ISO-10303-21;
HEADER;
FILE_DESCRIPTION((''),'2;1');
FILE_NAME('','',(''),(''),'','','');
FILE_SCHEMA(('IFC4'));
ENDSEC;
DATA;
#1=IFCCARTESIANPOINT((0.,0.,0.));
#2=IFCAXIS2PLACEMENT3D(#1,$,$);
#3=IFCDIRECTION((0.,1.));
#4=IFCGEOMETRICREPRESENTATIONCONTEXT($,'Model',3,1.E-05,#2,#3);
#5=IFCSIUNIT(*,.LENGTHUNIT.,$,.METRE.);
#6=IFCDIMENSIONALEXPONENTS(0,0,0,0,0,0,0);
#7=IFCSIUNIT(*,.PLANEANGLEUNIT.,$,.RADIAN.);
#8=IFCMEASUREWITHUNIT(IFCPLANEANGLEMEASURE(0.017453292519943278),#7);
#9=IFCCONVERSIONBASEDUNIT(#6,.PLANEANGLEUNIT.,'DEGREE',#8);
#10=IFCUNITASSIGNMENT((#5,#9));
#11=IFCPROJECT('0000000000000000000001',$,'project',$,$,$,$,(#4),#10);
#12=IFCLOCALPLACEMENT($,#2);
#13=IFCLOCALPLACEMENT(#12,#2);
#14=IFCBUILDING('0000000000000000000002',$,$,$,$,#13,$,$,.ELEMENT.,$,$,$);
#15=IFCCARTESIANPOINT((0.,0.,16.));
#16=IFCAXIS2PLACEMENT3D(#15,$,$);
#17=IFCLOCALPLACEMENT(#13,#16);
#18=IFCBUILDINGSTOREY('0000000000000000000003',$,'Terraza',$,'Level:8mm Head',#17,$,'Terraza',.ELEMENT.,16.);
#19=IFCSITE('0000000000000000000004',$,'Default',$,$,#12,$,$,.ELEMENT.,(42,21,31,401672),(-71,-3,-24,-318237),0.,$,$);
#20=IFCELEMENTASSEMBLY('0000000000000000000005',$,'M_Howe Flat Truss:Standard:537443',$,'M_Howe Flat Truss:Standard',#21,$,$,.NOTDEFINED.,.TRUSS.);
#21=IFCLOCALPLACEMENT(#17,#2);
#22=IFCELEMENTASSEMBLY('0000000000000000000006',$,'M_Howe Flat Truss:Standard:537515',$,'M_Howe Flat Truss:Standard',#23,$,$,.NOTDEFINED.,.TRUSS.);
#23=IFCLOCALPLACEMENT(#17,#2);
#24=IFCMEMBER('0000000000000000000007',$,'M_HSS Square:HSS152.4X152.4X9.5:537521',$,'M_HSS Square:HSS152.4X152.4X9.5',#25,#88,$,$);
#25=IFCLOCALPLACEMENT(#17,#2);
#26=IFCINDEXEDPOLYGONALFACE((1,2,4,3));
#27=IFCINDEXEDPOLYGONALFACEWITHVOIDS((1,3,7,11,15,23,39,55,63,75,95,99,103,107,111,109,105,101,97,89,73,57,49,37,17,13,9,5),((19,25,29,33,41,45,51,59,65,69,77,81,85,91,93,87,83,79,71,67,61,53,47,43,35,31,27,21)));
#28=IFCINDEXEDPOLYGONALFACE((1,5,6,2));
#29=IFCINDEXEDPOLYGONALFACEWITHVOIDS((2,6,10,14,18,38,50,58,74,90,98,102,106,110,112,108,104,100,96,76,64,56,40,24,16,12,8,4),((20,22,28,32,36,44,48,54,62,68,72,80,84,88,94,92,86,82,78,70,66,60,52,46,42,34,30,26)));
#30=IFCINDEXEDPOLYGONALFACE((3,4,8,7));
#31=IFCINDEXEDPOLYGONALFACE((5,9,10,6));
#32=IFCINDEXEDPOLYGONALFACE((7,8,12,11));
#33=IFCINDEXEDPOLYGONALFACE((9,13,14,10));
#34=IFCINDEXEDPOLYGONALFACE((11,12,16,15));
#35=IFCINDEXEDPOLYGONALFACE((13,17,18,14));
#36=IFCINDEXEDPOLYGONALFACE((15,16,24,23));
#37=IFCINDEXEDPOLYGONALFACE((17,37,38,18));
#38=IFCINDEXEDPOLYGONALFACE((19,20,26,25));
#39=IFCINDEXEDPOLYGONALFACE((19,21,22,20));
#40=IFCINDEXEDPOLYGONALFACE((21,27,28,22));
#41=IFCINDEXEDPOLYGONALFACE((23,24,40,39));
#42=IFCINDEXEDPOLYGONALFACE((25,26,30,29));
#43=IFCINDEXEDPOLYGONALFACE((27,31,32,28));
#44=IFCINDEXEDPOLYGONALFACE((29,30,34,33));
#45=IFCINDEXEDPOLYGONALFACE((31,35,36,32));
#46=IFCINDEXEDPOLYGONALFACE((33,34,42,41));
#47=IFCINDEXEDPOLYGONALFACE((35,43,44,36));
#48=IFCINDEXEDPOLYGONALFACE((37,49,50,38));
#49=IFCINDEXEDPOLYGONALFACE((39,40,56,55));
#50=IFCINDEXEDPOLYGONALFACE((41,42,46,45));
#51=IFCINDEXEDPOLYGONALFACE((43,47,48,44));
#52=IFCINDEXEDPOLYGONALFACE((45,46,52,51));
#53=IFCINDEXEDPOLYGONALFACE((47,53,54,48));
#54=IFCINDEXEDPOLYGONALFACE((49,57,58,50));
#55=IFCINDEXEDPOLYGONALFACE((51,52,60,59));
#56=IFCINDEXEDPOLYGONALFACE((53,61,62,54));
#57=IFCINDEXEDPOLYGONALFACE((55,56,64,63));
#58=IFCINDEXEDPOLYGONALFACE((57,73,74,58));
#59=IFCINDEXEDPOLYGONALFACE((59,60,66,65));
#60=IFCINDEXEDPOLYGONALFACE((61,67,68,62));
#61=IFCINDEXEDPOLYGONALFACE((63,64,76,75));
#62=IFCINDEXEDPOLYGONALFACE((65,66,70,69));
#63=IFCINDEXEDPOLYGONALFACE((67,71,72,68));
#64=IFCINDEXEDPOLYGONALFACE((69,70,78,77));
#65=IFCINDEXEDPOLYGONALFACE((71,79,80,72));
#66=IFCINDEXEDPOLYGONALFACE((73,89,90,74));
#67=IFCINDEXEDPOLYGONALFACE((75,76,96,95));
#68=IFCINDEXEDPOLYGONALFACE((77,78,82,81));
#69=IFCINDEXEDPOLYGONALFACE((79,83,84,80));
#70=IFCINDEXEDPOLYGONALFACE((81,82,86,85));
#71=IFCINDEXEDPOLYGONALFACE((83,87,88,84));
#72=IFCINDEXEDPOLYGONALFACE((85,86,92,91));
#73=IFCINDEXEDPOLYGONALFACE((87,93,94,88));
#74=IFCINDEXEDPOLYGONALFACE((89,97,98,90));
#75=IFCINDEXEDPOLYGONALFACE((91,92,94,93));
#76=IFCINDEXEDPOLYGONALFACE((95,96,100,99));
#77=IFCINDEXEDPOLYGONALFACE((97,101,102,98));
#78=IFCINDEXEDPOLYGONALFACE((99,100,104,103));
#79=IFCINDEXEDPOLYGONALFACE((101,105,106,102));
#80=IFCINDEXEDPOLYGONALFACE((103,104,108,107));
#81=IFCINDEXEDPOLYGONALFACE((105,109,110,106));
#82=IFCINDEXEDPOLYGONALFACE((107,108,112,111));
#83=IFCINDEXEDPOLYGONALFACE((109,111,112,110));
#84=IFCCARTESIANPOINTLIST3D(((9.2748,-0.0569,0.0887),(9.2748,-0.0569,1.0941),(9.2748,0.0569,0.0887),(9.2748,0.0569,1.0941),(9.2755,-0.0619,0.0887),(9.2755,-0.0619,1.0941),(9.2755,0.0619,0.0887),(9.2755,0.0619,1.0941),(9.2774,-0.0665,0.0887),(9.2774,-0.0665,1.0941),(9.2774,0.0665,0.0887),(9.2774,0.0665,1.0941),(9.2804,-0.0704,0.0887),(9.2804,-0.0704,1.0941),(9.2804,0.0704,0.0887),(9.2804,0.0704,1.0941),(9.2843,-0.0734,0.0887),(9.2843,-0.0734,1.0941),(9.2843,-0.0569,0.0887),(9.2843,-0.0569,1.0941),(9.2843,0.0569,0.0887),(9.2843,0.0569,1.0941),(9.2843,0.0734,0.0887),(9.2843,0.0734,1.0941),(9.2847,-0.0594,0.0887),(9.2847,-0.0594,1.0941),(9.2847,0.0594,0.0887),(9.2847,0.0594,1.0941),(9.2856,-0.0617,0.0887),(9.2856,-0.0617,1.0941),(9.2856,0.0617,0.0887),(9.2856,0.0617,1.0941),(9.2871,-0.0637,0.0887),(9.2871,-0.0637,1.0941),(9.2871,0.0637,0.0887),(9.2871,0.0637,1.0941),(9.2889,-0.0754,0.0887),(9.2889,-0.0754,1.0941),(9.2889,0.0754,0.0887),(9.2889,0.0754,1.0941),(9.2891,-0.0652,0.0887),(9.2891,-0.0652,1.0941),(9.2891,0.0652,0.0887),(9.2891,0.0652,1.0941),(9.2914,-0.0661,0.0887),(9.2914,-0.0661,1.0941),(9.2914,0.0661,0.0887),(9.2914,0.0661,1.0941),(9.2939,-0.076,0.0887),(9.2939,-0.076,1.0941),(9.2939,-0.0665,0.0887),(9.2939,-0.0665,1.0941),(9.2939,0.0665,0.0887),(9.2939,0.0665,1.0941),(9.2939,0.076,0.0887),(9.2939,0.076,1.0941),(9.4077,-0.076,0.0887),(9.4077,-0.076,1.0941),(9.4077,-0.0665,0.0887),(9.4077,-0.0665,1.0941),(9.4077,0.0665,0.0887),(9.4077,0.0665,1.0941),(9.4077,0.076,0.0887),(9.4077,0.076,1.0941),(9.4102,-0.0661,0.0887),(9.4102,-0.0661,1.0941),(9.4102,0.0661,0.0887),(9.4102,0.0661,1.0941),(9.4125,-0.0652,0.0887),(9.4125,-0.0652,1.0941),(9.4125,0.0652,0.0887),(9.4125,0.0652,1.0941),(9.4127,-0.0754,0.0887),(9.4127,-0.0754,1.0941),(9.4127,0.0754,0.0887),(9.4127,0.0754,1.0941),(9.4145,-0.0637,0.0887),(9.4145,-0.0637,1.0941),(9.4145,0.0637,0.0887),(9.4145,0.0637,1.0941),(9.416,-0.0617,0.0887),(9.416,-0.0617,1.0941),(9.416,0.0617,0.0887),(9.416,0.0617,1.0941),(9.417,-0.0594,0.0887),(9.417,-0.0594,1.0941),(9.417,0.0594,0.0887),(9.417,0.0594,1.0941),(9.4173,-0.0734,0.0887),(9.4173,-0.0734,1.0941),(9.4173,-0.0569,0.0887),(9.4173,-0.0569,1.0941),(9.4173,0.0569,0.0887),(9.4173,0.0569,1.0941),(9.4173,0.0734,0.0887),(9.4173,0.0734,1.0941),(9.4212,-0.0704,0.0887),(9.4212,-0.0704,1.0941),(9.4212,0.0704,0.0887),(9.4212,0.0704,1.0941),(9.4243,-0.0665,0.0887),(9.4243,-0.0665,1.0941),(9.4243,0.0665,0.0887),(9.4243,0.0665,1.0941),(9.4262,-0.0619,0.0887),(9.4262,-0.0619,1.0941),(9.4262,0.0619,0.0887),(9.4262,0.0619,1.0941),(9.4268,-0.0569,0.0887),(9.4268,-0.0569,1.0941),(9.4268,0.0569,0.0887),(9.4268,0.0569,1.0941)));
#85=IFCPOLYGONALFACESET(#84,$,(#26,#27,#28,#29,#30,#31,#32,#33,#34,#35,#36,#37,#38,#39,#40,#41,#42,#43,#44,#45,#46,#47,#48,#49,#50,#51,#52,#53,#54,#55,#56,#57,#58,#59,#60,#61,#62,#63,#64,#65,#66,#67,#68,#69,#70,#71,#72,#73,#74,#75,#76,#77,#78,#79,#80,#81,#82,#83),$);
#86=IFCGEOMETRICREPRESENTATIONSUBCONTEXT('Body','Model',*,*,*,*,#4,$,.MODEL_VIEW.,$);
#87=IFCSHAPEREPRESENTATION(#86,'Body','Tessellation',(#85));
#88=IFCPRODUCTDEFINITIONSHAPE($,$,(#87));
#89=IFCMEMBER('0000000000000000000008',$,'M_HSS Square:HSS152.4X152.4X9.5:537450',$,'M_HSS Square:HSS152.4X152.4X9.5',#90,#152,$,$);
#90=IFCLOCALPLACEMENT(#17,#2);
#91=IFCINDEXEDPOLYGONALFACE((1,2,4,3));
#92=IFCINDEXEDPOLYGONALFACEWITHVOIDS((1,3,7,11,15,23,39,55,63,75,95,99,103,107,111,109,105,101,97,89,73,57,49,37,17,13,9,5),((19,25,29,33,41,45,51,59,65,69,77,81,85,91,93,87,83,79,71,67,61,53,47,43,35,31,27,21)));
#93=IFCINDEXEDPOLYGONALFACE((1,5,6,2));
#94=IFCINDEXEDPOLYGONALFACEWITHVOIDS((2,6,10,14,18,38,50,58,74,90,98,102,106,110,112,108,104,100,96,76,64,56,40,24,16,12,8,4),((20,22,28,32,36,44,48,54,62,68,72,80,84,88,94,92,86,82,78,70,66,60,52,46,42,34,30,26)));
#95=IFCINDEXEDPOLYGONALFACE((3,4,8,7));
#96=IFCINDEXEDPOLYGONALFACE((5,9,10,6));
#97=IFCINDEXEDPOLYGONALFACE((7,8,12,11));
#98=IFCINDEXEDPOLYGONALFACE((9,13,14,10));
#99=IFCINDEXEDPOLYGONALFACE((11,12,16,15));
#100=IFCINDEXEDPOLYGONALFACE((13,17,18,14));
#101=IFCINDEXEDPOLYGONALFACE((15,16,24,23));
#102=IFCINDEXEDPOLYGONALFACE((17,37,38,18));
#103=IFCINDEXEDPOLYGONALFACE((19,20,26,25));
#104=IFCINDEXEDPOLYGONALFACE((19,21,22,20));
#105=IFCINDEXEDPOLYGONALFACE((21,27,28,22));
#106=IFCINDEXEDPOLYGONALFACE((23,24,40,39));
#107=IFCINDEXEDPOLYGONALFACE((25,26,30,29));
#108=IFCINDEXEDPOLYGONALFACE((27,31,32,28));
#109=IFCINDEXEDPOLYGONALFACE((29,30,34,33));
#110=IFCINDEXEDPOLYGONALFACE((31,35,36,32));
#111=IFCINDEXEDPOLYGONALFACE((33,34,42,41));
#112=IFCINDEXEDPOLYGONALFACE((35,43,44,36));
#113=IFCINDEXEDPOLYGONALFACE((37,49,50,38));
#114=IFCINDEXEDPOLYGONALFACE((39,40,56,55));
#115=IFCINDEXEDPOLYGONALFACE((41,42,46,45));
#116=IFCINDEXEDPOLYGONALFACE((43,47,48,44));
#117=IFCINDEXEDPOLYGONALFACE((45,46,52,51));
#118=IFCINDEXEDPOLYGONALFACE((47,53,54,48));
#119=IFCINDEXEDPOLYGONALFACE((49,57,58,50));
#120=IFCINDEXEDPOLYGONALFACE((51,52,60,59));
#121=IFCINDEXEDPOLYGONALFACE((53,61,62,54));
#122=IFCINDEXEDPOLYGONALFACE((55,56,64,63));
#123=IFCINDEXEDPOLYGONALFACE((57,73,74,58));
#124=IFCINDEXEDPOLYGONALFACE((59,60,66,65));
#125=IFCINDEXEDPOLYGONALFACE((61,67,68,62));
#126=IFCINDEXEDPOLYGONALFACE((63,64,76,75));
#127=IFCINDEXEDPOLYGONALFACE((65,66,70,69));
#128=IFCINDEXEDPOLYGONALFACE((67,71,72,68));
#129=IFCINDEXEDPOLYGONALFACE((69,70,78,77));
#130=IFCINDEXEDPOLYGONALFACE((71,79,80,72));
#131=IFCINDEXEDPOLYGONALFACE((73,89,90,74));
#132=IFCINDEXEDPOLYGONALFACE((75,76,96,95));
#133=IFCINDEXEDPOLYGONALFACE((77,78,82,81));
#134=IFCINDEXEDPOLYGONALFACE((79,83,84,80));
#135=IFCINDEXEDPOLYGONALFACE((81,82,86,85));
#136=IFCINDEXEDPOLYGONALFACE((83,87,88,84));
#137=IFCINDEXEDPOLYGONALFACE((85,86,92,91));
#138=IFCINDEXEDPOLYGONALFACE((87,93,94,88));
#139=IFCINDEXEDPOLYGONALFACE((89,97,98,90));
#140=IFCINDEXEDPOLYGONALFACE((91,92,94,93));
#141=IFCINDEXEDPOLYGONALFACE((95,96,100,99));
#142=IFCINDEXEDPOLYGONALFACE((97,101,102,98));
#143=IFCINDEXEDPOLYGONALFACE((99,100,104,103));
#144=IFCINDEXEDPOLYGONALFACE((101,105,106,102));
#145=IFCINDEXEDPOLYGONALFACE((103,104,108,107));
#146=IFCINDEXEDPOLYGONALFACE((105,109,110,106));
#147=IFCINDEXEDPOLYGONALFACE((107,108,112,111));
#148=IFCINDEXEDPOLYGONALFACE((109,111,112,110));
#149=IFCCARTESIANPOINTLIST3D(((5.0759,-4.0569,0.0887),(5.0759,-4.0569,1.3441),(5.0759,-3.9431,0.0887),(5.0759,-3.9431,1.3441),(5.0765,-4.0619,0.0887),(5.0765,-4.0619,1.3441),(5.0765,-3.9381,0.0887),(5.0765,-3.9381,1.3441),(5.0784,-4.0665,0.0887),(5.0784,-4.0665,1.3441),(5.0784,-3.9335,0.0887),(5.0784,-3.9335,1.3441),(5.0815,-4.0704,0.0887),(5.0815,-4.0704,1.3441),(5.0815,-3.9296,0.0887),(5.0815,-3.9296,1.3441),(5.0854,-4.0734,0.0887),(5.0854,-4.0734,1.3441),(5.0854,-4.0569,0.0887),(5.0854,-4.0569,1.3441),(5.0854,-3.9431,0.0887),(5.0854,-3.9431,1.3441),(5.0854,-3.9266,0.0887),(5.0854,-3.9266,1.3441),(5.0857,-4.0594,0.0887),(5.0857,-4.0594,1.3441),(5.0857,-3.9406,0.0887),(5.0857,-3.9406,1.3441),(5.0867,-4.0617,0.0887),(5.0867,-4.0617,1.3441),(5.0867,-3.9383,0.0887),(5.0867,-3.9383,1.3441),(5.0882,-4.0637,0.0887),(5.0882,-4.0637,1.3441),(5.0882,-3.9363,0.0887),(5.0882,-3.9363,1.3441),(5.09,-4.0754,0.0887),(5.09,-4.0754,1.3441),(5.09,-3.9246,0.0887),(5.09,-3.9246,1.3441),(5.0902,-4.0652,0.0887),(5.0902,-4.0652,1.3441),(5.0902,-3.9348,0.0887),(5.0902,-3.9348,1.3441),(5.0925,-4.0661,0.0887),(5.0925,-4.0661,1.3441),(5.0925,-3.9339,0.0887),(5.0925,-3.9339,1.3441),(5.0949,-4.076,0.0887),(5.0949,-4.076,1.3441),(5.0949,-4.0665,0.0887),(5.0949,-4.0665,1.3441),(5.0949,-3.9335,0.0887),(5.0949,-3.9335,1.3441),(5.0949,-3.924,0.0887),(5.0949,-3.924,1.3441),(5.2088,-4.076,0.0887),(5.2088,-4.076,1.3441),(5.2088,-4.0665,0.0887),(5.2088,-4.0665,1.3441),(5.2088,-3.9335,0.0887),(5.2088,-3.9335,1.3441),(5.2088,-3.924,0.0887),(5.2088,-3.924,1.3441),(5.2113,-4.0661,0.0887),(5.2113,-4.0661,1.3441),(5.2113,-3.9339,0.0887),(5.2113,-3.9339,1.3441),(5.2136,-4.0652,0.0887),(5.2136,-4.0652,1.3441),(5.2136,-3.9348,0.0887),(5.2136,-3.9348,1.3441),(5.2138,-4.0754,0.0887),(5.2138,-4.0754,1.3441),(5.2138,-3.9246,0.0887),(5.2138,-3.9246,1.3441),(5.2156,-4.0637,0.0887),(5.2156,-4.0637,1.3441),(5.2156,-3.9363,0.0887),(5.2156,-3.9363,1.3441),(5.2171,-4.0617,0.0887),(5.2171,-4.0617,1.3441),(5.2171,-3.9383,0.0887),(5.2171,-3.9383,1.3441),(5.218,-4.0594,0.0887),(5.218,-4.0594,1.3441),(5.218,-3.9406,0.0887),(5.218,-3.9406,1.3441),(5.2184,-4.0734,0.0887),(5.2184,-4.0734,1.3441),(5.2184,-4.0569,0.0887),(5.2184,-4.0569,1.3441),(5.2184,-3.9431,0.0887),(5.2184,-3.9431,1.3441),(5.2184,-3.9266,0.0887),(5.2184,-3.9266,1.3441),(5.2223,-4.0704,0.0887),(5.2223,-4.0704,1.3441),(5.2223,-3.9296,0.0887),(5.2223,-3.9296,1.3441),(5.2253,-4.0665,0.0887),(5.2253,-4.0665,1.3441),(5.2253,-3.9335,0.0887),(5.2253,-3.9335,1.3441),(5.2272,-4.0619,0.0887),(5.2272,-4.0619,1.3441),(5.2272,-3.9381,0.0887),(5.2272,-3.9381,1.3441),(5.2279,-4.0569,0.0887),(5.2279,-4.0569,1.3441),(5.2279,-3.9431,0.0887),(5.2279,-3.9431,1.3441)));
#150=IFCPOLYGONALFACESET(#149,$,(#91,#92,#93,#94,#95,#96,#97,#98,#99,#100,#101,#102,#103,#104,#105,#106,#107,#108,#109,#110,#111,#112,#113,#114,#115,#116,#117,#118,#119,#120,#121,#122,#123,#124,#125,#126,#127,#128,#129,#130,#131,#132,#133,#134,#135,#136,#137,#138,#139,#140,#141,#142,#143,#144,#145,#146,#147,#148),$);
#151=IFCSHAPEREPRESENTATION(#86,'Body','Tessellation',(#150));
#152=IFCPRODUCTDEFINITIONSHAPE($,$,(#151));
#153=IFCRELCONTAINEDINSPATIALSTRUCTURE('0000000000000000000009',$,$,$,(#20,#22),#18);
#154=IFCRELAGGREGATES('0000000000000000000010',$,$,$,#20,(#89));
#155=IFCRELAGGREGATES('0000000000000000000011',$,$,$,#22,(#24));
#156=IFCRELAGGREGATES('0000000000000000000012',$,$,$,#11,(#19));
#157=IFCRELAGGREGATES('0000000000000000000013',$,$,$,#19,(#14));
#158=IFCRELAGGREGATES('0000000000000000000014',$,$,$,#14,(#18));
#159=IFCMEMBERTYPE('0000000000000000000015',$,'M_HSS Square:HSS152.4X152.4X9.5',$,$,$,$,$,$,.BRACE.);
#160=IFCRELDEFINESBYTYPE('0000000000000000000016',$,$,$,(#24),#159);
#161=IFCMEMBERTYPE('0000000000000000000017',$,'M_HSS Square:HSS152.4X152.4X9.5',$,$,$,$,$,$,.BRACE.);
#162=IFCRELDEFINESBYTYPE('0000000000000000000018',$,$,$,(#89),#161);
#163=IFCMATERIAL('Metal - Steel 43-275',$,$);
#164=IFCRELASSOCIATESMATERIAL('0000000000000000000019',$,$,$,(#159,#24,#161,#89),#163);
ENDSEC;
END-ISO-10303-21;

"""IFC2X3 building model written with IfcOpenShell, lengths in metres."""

from ifc_helpers import new_model, entity, si_unit, converted_unit, direction, frame, frame_2d, origin, place, context, subcontext, project, spatial, polyline, circle_curve, parameter, trimmed, segment, composite_curve, outline, extrude, source, transform, mapped, material, type_object, type_shapes, element, aggregate, save


model = new_model("IFC2X3")

# Units and contexts
model_context = context("Model", 3, precision=1e-05, world=origin(), true_north=direction((0.0, 1.0)))
body_context = subcontext(model_context, "Body", "Model", "MODEL_VIEW")
ifc_project = project(units=[si_unit("LENGTHUNIT", "METRE"), converted_unit("PLANEANGLEUNIT", "DEGREE", entity("IfcPlaneAngleMeasure", 0.017453292519943278), si_unit("PLANEANGLEUNIT", "RADIAN"), dimensions=[0, 0, 0, 0, 0, 0, 0])], contexts=[model_context])

# Site, building, storey
site_placement = place(None, origin())
site = spatial("IfcSite", under=ifc_project, at=site_placement, Name="Default", CompositionType="ELEMENT", RefLatitude=(42, 21, 31, 401672), RefLongitude=(-71, -3, -24, -318237), RefElevation=0.0)
building_placement = place(site_placement, origin())
building = spatial("IfcBuilding", under=site, at=building_placement, CompositionType="ELEMENT")
storey_placement = place(building_placement, frame((0.0, 0.0, 16.0)))
storey = spatial("IfcBuildingStorey", under=building, at=storey_placement, Name="Terraza", ObjectType="Level:8mm Head", LongName="Terraza", CompositionType="ELEMENT", Elevation=16.0)

# Element assemblies
ifc_material_1 = material(Name="Metal - Steel 43-275")
assembly_1_placement = place(storey_placement, origin())
assembly_1 = element("IfcElementAssembly", 1, at=assembly_1_placement, inside=storey, Name="M_Howe Flat Truss:Standard:537443", ObjectType="M_Howe Flat Truss:Standard", AssemblyPlace="NOTDEFINED", PredefinedType="TRUSS")
assembly_2_placement = place(storey_placement, origin())
assembly_2 = element("IfcElementAssembly", 2, at=assembly_2_placement, inside=storey, Name="M_Howe Flat Truss:Standard:537515", ObjectType="M_Howe Flat Truss:Standard", AssemblyPlace="NOTDEFINED", PredefinedType="TRUSS")

# Members
member_type_1 = type_object("IfcMemberType", Name="M_HSS Square:HSS152.4X152.4X9.5", PredefinedType="BRACE", material=ifc_material_1)
shared_shape_1 = source(origin(), body_context, "Body", "SweptSolid", [
    extrude(outline(composite_curve([segment(polyline([(-0.0569, -0.076), (0.0569, -0.076)]), True, "CONTINUOUS"), segment(trimmed(circle_curve(frame_2d((0.0569, -0.0569), x_axis=(0.0, 1.0)), 0.0191), [parameter(180.0)], [parameter(270.0)], True, "PARAMETER"), True, "CONTINUOUS"), segment(polyline([(0.076, -0.0569), (0.076, 0.0569)]), True, "CONTINUOUS"), segment(trimmed(circle_curve(frame_2d((0.0569, 0.0569), x_axis=(0.0, 1.0)), 0.0191), [parameter(270.0)], [parameter(0.0)], True, "PARAMETER"), True, "CONTINUOUS"), segment(polyline([(0.0569, 0.076), (-0.0569, 0.076)]), True, "CONTINUOUS"), segment(trimmed(circle_curve(frame_2d((-0.0569, 0.0569), x_axis=(0.0, 1.0)), 0.0191), [parameter(0.0)], [parameter(90.0)], True, "PARAMETER"), True, "CONTINUOUS"), segment(polyline([(-0.076, 0.0569), (-0.076, -0.0569)]), True, "CONTINUOUS"), segment(trimmed(circle_curve(frame_2d((-0.0569, -0.0569), x_axis=(0.0, 1.0)), 0.0191), [parameter(90.0)], [parameter(180.0)], True, "PARAMETER"), True, "CONTINUOUS")], self_intersect=False), holes=[composite_curve([segment(trimmed(circle_curve(frame_2d((-0.0569, 0.0569), x_axis=(0.0, 1.0)), 0.0095), [parameter(360.0)], [parameter(90.0)], True, "PARAMETER"), False, "CONTINUOUS"), segment(polyline([(-0.0569, 0.0665), (0.0569, 0.0665)]), True, "CONTINUOUS"), segment(trimmed(circle_curve(frame_2d((0.0569, 0.0569), x_axis=(0.0, 1.0)), 0.0095), [parameter(270.0)], [parameter(360.0)], True, "PARAMETER"), False, "CONTINUOUS"), segment(polyline([(0.0665, 0.0569), (0.0665, -0.0569)]), True, "CONTINUOUS"), segment(trimmed(circle_curve(frame_2d((0.0569, -0.0569), x_axis=(0.0, 1.0)), 0.0095), [parameter(180.0)], [parameter(270.0)], True, "PARAMETER"), False, "CONTINUOUS"), segment(polyline([(0.0569, -0.0665), (-0.0569, -0.0665)]), True, "CONTINUOUS"), segment(trimmed(circle_curve(frame_2d((-0.0569, -0.0569), x_axis=(0.0, 1.0)), 0.0095), [parameter(90.0)], [parameter(180.0)], True, "PARAMETER"), False, "CONTINUOUS"), segment(polyline([(-0.0665, -0.0569), (-0.0665, 0.0569)]), True, "CONTINUOUS")], self_intersect=False)]), frame((-0.505, 0.0, 0.0), z_axis=(1.0, 0.0, 0.0), x_axis=(0.0, 0.0, -1.0)), (0.0, 0.0, 1.0), 1.0054),
])
type_shapes(member_type_1, [shared_shape_1])
member_1_placement = place(assembly_2_placement, frame((9.3508, 0.0, 0.5937), z_axis=(1.0, 0.0, 0.0), x_axis=(0.0, 0.0, 1.0)))
member_1 = element("IfcMember", 3, at=member_1_placement, type_object=member_type_1, material=ifc_material_1, Name="M_HSS Square:HSS152.4X152.4X9.5:537521", ObjectType="M_HSS Square:HSS152.4X152.4X9.5", context=body_context, shape_type="MappedRepresentation", body=[
    mapped(shared_shape_1, transform((0.0, 0.0, 0.0), scale=1.0)),
])
member_type_2 = type_object("IfcMemberType", Name="M_HSS Square:HSS152.4X152.4X9.5", PredefinedType="BRACE", material=ifc_material_1)
shared_shape_2 = source(origin(), body_context, "Body", "SweptSolid", [
    extrude(outline(composite_curve([segment(polyline([(-0.0569, -0.076), (0.0569, -0.076)]), True, "CONTINUOUS"), segment(trimmed(circle_curve(frame_2d((0.0569, -0.0569), x_axis=(0.0, 1.0)), 0.0191), [parameter(180.0)], [parameter(270.0)], True, "PARAMETER"), True, "CONTINUOUS"), segment(polyline([(0.076, -0.0569), (0.076, 0.0569)]), True, "CONTINUOUS"), segment(trimmed(circle_curve(frame_2d((0.0569, 0.0569), x_axis=(0.0, 1.0)), 0.0191), [parameter(270.0)], [parameter(0.0)], True, "PARAMETER"), True, "CONTINUOUS"), segment(polyline([(0.0569, 0.076), (-0.0569, 0.076)]), True, "CONTINUOUS"), segment(trimmed(circle_curve(frame_2d((-0.0569, 0.0569), x_axis=(0.0, 1.0)), 0.0191), [parameter(0.0)], [parameter(90.0)], True, "PARAMETER"), True, "CONTINUOUS"), segment(polyline([(-0.076, 0.0569), (-0.076, -0.0569)]), True, "CONTINUOUS"), segment(trimmed(circle_curve(frame_2d((-0.0569, -0.0569), x_axis=(0.0, 1.0)), 0.0191), [parameter(90.0)], [parameter(180.0)], True, "PARAMETER"), True, "CONTINUOUS")], self_intersect=False), holes=[composite_curve([segment(trimmed(circle_curve(frame_2d((-0.0569, 0.0569), x_axis=(0.0, 1.0)), 0.0095), [parameter(360.0)], [parameter(90.0)], True, "PARAMETER"), False, "CONTINUOUS"), segment(polyline([(-0.0569, 0.0665), (0.0569, 0.0665)]), True, "CONTINUOUS"), segment(trimmed(circle_curve(frame_2d((0.0569, 0.0569), x_axis=(0.0, 1.0)), 0.0095), [parameter(270.0)], [parameter(360.0)], True, "PARAMETER"), False, "CONTINUOUS"), segment(polyline([(0.0665, 0.0569), (0.0665, -0.0569)]), True, "CONTINUOUS"), segment(trimmed(circle_curve(frame_2d((0.0569, -0.0569), x_axis=(0.0, 1.0)), 0.0095), [parameter(180.0)], [parameter(270.0)], True, "PARAMETER"), False, "CONTINUOUS"), segment(polyline([(0.0569, -0.0665), (-0.0569, -0.0665)]), True, "CONTINUOUS"), segment(trimmed(circle_curve(frame_2d((-0.0569, -0.0569), x_axis=(0.0, 1.0)), 0.0095), [parameter(90.0)], [parameter(180.0)], True, "PARAMETER"), False, "CONTINUOUS"), segment(polyline([(-0.0665, -0.0569), (-0.0665, 0.0569)]), True, "CONTINUOUS")], self_intersect=False)]), frame((-0.63, 0.0, 0.0), z_axis=(1.0, 0.0, 0.0), x_axis=(0.0, 0.0, -1.0)), (0.0, 0.0, 1.0), 1.2554),
])
type_shapes(member_type_2, [shared_shape_2])
member_2_placement = place(assembly_1_placement, frame((5.1519, -4.0, 0.7187), z_axis=(1.0, 0.0, 0.0), x_axis=(0.0, 0.0, 1.0)))
member_2 = element("IfcMember", 4, at=member_2_placement, type_object=member_type_2, material=ifc_material_1, Name="M_HSS Square:HSS152.4X152.4X9.5:537450", ObjectType="M_HSS Square:HSS152.4X152.4X9.5", context=body_context, shape_type="MappedRepresentation", body=[
    mapped(shared_shape_2, transform((0.0, 0.0, 0.0), scale=1.0)),
])
aggregate(assembly_1, [member_2])
aggregate(assembly_2, [member_1])

save(model, "model.ifc")
